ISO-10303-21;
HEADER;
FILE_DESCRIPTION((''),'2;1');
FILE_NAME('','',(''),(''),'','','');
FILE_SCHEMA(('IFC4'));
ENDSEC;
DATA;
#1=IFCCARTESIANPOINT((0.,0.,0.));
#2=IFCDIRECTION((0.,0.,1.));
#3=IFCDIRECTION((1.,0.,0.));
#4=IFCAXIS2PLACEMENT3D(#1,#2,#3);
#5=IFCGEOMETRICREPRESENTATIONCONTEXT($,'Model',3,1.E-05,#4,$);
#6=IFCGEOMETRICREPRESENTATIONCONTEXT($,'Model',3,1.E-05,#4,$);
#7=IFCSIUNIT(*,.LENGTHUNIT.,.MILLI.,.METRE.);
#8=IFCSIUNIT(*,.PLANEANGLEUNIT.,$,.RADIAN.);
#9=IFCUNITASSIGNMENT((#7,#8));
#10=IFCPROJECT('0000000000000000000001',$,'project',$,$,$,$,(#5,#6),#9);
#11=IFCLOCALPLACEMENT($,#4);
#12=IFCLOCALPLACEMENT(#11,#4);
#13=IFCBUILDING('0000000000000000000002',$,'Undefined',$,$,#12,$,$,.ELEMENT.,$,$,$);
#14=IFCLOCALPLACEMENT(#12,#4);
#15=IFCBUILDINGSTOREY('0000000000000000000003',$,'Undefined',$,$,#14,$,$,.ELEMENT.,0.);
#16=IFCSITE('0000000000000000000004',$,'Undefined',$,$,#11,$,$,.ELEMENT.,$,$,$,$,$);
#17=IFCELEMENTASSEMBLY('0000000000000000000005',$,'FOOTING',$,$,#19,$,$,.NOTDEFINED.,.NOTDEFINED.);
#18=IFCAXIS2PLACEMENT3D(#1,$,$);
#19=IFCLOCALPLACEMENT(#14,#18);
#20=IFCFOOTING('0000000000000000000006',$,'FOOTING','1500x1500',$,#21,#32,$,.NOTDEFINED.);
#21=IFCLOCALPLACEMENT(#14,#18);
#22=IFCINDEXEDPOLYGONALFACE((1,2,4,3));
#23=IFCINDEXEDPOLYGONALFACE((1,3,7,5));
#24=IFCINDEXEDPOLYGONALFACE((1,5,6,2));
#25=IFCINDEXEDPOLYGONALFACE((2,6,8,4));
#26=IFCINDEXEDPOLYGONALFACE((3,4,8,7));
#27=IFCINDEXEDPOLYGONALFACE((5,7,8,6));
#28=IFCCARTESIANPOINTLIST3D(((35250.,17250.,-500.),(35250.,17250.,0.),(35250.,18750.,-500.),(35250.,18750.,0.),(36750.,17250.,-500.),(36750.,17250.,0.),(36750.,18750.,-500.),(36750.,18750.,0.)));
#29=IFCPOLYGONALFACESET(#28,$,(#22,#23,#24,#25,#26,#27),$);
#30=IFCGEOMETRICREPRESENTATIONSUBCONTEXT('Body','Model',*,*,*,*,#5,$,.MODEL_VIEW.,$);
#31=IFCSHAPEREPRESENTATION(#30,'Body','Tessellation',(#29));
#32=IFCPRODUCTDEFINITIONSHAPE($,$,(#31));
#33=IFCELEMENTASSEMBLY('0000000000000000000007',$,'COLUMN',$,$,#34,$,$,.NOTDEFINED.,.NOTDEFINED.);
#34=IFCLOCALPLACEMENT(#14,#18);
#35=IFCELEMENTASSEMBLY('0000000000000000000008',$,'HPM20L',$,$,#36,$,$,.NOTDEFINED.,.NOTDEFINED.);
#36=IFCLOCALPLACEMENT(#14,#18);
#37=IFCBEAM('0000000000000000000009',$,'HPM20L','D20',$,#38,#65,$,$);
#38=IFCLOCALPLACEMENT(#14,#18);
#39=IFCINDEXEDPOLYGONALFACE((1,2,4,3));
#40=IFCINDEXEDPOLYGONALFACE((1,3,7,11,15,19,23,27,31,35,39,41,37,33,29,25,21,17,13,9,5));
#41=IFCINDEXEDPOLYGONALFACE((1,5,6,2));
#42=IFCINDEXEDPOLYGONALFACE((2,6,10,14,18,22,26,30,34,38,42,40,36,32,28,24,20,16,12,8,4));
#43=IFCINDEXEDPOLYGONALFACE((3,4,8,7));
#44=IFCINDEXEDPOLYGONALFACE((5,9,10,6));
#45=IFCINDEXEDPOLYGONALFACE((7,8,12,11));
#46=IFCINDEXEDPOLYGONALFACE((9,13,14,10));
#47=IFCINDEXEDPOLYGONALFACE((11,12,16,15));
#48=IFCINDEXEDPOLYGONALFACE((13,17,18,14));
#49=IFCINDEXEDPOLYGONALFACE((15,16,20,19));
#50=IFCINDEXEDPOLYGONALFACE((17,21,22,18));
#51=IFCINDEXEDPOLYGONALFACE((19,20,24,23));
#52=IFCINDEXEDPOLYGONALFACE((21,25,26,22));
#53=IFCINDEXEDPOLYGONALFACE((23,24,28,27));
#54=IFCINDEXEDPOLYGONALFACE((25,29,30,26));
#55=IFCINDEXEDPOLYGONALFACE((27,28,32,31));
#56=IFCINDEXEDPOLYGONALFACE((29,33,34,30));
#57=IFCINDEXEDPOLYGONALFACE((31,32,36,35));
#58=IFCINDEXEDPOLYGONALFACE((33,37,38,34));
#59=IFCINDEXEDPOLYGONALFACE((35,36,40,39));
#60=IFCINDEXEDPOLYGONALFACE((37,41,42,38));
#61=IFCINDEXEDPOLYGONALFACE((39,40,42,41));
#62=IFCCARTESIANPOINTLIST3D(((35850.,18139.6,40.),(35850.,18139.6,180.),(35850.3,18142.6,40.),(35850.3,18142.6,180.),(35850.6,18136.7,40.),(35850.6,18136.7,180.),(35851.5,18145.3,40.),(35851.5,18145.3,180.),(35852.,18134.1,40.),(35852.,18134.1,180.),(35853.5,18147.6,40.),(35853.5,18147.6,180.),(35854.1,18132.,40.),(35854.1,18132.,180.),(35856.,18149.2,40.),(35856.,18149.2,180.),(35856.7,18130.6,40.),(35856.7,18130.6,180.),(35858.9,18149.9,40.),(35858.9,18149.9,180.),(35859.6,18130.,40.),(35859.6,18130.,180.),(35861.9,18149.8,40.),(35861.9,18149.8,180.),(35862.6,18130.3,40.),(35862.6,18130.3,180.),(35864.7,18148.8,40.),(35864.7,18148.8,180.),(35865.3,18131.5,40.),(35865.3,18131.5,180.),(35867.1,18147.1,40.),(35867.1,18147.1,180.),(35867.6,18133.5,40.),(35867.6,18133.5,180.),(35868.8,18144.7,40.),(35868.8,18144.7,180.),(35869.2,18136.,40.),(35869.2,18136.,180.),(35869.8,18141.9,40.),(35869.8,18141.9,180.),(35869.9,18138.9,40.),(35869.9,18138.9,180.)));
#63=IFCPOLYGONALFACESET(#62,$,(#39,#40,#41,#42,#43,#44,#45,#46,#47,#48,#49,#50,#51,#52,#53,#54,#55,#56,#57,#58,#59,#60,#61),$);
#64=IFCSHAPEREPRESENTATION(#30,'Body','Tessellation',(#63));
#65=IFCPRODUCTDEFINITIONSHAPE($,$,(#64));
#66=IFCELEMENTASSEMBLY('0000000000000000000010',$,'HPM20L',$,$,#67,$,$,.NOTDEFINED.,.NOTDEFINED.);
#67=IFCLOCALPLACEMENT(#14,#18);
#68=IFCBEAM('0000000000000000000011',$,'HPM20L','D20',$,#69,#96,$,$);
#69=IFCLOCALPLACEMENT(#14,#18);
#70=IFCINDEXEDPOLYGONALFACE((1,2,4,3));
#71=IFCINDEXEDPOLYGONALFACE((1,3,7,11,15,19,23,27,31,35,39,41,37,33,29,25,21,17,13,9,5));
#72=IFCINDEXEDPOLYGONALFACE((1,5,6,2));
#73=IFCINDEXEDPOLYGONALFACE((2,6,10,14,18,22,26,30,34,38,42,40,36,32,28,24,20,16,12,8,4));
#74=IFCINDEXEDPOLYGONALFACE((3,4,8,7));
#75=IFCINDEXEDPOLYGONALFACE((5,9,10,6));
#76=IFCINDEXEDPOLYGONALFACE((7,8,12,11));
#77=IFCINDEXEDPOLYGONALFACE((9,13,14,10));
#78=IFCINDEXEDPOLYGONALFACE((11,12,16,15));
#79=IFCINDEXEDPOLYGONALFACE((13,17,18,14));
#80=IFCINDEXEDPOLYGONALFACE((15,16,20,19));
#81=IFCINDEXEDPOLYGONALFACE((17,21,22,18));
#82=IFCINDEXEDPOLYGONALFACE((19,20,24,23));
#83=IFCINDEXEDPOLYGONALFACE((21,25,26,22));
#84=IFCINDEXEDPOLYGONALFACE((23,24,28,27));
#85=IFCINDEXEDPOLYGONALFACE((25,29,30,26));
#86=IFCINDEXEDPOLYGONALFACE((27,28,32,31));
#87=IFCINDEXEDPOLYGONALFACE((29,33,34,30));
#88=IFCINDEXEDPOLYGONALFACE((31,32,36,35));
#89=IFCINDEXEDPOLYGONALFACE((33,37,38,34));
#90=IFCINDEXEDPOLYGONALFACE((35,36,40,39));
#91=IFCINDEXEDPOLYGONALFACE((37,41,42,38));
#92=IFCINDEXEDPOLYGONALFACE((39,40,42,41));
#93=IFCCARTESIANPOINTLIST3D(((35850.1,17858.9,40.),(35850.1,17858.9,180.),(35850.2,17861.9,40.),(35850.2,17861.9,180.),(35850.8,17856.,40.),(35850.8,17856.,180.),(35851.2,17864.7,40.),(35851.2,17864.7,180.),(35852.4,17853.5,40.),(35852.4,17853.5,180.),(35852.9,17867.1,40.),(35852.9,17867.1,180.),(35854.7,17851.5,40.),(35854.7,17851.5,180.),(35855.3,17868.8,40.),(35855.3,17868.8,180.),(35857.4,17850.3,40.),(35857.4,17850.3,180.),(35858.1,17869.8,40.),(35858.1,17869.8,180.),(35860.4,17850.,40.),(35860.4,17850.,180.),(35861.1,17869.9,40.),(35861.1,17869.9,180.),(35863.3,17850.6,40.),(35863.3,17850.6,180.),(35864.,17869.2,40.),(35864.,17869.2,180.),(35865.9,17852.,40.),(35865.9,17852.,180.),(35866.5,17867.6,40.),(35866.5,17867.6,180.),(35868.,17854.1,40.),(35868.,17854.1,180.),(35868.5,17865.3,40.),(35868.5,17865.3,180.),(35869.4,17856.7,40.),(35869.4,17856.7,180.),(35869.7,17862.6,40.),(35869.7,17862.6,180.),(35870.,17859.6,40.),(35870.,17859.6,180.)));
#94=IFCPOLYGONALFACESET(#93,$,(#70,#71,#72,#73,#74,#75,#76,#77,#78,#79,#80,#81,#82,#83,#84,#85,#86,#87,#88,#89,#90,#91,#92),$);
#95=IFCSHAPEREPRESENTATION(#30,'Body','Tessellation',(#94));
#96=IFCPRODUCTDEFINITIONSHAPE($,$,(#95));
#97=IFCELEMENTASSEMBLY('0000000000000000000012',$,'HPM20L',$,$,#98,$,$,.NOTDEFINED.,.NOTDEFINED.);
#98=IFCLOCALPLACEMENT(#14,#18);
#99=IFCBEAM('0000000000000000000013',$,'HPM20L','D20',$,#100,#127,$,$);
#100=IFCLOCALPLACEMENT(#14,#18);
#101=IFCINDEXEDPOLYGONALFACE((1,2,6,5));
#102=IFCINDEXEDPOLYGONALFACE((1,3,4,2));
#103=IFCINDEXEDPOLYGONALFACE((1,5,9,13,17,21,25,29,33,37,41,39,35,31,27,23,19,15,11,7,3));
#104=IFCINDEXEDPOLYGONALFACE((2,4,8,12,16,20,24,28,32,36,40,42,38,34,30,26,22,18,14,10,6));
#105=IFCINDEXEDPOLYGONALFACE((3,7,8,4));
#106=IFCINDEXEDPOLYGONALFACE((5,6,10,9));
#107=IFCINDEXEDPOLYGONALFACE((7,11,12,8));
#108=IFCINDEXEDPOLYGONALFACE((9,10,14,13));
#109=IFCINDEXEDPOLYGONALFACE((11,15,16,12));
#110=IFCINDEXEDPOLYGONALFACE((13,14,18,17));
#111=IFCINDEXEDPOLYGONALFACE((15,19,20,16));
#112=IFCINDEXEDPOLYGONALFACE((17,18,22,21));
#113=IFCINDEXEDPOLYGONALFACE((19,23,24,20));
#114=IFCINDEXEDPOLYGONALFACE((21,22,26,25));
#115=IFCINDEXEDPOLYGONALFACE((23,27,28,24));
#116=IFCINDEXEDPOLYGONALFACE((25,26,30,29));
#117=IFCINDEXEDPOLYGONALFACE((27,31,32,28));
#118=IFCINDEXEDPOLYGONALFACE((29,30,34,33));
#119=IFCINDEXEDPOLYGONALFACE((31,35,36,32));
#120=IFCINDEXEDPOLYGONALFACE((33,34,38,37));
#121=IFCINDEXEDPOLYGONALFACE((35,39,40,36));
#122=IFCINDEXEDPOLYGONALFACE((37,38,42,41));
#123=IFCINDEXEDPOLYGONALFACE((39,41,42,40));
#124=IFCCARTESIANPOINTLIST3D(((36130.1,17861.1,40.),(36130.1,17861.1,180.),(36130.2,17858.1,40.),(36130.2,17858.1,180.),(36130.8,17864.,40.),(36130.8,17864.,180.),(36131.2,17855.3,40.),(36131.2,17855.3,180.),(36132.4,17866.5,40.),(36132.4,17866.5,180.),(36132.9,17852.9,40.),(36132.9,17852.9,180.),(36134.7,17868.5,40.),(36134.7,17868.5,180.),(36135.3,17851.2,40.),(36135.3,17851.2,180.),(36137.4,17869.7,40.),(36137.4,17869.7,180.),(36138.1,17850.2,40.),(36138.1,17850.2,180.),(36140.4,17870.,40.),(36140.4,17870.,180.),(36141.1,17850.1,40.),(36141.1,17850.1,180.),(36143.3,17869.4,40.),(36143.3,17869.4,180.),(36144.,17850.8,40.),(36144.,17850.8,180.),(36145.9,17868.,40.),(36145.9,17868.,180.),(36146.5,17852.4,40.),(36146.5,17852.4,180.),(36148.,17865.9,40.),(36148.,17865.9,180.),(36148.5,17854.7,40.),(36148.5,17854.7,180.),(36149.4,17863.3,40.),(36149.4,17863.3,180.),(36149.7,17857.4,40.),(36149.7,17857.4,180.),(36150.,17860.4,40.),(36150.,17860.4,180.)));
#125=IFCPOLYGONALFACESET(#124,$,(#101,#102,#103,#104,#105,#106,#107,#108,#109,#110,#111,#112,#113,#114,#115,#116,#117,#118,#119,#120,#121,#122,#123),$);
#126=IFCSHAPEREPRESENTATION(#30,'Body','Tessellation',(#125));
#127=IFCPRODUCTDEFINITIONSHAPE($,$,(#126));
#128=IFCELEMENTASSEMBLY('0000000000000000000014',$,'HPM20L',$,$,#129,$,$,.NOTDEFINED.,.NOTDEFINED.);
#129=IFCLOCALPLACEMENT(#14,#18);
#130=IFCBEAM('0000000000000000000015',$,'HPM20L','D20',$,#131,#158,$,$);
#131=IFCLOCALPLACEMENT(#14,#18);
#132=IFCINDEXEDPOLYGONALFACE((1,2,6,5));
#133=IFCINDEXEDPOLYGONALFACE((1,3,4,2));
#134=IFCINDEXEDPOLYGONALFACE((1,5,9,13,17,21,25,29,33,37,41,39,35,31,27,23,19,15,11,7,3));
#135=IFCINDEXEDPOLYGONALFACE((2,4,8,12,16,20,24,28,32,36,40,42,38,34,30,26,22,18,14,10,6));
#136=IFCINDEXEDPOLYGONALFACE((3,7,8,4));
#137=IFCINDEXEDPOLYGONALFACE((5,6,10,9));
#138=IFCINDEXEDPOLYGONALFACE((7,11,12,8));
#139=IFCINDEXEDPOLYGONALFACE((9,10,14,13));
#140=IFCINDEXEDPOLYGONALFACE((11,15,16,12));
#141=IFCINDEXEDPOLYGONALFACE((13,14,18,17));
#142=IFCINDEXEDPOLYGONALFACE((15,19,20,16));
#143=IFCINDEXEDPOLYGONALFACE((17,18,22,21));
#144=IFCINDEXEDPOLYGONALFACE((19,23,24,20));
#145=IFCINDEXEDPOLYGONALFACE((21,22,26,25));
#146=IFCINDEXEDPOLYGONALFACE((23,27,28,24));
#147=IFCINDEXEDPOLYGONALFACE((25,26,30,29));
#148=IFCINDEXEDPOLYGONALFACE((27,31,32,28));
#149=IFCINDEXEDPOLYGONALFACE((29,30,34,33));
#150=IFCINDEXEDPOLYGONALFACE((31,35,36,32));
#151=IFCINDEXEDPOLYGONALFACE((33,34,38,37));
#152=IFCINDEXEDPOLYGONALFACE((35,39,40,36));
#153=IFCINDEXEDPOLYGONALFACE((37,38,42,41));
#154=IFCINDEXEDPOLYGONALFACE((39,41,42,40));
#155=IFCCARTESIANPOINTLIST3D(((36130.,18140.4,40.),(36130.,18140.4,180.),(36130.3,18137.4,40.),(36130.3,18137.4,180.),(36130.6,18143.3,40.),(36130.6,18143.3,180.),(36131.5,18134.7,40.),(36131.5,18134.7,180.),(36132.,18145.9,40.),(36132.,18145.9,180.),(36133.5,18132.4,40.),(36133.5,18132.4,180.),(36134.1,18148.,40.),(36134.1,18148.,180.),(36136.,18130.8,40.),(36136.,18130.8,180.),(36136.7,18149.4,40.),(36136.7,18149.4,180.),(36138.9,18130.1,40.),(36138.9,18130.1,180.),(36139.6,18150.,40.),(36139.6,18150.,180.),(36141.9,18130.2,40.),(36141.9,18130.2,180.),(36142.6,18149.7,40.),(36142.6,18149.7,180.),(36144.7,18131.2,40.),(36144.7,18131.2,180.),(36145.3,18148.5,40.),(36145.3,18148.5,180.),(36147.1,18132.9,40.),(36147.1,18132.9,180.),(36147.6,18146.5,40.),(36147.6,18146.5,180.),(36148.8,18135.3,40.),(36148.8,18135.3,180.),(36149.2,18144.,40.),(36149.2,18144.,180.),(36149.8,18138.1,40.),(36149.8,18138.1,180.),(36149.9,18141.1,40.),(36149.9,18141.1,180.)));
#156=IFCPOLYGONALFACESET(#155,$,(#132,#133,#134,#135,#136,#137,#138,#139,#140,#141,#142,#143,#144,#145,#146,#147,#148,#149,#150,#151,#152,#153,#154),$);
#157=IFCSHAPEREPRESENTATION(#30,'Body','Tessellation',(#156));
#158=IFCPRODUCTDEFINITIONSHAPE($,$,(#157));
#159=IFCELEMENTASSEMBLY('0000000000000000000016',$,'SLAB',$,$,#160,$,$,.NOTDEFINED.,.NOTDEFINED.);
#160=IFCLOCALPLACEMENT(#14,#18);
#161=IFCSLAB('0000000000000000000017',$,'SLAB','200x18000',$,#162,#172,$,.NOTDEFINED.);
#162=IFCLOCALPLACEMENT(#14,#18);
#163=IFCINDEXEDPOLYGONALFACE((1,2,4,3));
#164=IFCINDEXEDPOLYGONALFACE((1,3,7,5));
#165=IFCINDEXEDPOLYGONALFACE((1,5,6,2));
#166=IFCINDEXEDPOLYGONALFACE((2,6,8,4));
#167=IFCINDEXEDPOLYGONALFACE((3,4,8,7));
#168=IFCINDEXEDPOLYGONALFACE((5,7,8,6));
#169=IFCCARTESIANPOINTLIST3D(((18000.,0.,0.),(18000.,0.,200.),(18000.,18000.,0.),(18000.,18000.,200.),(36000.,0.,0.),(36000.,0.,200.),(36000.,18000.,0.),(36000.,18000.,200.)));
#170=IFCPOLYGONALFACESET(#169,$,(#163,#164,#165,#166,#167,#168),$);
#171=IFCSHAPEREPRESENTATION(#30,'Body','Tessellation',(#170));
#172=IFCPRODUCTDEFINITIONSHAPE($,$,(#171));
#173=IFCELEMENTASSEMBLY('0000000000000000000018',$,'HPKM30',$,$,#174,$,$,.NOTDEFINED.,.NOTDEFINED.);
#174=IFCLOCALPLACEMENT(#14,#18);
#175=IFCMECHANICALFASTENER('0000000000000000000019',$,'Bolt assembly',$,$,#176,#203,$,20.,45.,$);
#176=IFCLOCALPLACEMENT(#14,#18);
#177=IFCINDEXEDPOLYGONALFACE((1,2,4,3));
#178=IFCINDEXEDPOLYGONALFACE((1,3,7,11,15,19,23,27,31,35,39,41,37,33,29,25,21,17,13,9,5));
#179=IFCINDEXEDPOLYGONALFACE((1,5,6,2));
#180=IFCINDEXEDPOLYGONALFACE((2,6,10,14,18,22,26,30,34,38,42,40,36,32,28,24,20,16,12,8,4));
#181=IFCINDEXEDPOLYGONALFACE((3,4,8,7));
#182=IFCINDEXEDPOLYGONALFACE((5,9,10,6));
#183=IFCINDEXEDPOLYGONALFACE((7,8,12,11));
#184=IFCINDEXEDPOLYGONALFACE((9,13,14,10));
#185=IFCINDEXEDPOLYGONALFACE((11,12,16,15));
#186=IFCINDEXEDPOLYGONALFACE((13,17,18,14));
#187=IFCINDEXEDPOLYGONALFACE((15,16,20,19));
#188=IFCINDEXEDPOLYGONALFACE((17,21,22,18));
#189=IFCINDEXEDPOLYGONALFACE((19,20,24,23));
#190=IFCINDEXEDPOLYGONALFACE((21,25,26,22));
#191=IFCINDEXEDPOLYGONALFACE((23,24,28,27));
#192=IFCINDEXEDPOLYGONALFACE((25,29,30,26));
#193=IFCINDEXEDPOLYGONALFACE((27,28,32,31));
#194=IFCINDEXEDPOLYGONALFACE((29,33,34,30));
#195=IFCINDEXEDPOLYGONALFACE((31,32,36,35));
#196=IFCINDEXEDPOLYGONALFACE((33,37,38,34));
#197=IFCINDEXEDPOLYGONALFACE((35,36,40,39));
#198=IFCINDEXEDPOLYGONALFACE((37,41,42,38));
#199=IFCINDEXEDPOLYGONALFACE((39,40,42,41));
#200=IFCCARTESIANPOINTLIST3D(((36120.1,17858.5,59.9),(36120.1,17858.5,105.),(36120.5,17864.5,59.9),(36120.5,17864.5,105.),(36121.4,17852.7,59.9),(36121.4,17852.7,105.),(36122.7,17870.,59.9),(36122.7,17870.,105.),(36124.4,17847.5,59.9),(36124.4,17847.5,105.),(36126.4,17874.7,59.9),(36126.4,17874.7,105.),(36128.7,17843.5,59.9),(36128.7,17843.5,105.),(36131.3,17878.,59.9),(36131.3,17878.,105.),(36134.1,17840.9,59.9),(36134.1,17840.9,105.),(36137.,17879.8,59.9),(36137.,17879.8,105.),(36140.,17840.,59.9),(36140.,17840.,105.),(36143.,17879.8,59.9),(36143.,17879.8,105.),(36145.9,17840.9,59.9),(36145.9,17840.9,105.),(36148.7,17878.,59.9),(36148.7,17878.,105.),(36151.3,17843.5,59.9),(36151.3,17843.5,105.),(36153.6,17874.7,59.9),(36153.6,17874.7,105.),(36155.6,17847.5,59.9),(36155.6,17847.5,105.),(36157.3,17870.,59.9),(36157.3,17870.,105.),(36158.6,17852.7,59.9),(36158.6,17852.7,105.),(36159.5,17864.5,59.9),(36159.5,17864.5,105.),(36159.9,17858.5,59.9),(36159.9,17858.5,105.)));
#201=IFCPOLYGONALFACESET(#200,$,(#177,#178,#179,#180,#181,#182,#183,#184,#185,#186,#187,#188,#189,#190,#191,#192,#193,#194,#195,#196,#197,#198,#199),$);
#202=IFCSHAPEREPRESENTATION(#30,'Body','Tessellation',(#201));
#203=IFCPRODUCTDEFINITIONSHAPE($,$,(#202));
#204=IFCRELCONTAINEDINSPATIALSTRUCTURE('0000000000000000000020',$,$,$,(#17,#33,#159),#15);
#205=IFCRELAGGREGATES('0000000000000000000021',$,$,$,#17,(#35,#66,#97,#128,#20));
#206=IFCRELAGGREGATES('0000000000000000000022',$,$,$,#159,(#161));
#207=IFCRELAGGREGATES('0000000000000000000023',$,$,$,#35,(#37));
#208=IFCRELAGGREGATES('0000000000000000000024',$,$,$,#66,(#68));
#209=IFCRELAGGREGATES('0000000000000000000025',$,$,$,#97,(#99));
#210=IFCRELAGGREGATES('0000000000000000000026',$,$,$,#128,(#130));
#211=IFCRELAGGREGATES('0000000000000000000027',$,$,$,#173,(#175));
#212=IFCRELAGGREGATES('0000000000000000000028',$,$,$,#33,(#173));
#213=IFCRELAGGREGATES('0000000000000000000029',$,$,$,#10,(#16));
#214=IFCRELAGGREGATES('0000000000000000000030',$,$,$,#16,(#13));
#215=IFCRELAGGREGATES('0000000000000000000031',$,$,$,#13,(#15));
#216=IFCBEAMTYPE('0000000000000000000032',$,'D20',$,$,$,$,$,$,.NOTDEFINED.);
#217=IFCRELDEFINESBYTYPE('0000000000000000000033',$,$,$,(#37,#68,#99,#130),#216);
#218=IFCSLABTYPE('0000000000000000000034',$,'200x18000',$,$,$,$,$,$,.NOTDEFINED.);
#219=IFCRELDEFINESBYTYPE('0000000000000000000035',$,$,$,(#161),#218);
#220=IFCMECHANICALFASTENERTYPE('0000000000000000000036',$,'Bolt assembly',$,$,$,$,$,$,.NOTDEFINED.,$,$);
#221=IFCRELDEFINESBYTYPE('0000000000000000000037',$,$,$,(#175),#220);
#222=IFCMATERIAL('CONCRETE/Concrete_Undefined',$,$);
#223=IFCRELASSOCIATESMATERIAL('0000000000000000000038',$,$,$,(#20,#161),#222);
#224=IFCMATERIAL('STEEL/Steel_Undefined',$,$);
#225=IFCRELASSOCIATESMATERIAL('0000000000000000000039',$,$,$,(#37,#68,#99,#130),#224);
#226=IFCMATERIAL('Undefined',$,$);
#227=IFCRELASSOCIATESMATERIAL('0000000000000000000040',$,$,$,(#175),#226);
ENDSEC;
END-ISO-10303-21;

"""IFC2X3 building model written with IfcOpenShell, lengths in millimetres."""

from ifc_helpers import new_model, si_unit, frame, origin_with_axes, origin_2d_with_axis, place, context, subcontext, project, spatial, polyline, rectangle, circle, outline, extrude, source, transform, mapped, material, type_object, element, aggregate, save


model = new_model("IFC2X3")

# Units and contexts
model_context_1 = context("Model", 3, precision=1e-05, world=origin_with_axes())
model_context_2 = context("Model", 3, precision=1e-05, world=origin_with_axes())
body_context = subcontext(model_context_1, "Body", "Model", "MODEL_VIEW")
ifc_project = project(units=[si_unit("LENGTHUNIT", "METRE", prefix="MILLI"), si_unit("PLANEANGLEUNIT", "RADIAN")], contexts=[model_context_1, model_context_2])

# Site, building, storey
site_placement = place(None, origin_with_axes())
site = spatial("IfcSite", under=ifc_project, at=site_placement, Name="Undefined", CompositionType="ELEMENT")
building_placement = place(site_placement, origin_with_axes())
building = spatial("IfcBuilding", under=site, at=building_placement, Name="Undefined", CompositionType="ELEMENT")
storey_placement = place(building_placement, origin_with_axes())
storey = spatial("IfcBuildingStorey", under=building, at=storey_placement, Name="Undefined", CompositionType="ELEMENT", Elevation=0.0)

# Element assembly, footing
assembly_1_placement = place(storey_placement, origin_with_axes())
assembly_1 = element("IfcElementAssembly", 1, at=assembly_1_placement, inside=storey, Name="FOOTING", AssemblyPlace="NOTDEFINED", PredefinedType="NOTDEFINED")
ifc_material_1 = material(Name="CONCRETE/Concrete_Undefined")
footing_placement = place(assembly_1_placement, frame((36000.0, 18000.0, -500.0), z_axis=(0.0, 1.0, 0.0), x_axis=(0.0, 0.0, 1.0)))
footing = element("IfcFooting", 2, at=footing_placement, material=ifc_material_1, Name="FOOTING", Description="1500x1500", PredefinedType="NOTDEFINED", context=body_context, shape_type="SweptSolid", body=[
    extrude(rectangle(XDim=1500.0, YDim=1500.0, at=origin_2d_with_axis()), frame((500.0, 0.0, 0.0), z_axis=(-1.0, 0.0, 0.0), x_axis=(0.0, -1.0, 0.0)), (0.0, 0.0, 1.0), 500.0),
])

# Element assembly
assembly_2_placement = place(storey_placement, origin_with_axes())
assembly_2 = element("IfcElementAssembly", 3, at=assembly_2_placement, inside=storey, Name="COLUMN", AssemblyPlace="NOTDEFINED", PredefinedType="NOTDEFINED")

# Element assemblies, beams
assembly_3_placement = place(assembly_1_placement, origin_with_axes())
assembly_3 = element("IfcElementAssembly", 4, at=assembly_3_placement, Name="HPM20L", AssemblyPlace="NOTDEFINED", PredefinedType="NOTDEFINED")
ifc_material_2 = material(Name="STEEL/Steel_Undefined")
beam_type = type_object("IfcBeamType", Name="D20", PredefinedType="NOTDEFINED")
beam_1_placement = place(assembly_3_placement, frame((35860.0, 18140.0, 180.0), z_axis=(-0.707107, 0.707107, 0.0), x_axis=(0.0, 0.0, -1.0)))
beam_1 = element("IfcBeam", 5, at=beam_1_placement, type_object=beam_type, material=ifc_material_2, Name="HPM20L", Description="D20", context=body_context, shape_type="SweptSolid", body=[
    extrude(circle(Radius=10.0, at=origin_2d_with_axis()), frame((140.0, 0.0, 0.0), z_axis=(-1.0, 0.0, 0.0), x_axis=(0.0, -1.0, 0.0)), (0.0, 0.0, 1.0), 140.0),
])
assembly_4_placement = place(assembly_1_placement, origin_with_axes())
assembly_4 = element("IfcElementAssembly", 6, at=assembly_4_placement, Name="HPM20L", AssemblyPlace="NOTDEFINED", PredefinedType="NOTDEFINED")
beam_2_placement = place(assembly_4_placement, frame((35860.0, 17860.0, 180.0), z_axis=(-0.707107, -0.707107, 0.0), x_axis=(0.0, 0.0, -1.0)))
beam_2 = element("IfcBeam", 7, at=beam_2_placement, type_object=beam_type, material=ifc_material_2, Name="HPM20L", Description="D20", context=body_context, shape_type="SweptSolid", body=[
    extrude(circle(Radius=10.0, at=origin_2d_with_axis()), frame((140.0, 0.0, 0.0), z_axis=(-1.0, 0.0, 0.0), x_axis=(0.0, -1.0, 0.0)), (0.0, 0.0, 1.0), 140.0),
])
assembly_5_placement = place(assembly_1_placement, origin_with_axes())
assembly_5 = element("IfcElementAssembly", 8, at=assembly_5_placement, Name="HPM20L", AssemblyPlace="NOTDEFINED", PredefinedType="NOTDEFINED")
beam_3_placement = place(assembly_5_placement, frame((36140.0, 17860.0, 180.0), z_axis=(0.707107, -0.707107, 0.0), x_axis=(0.0, 0.0, -1.0)))
beam_3 = element("IfcBeam", 9, at=beam_3_placement, type_object=beam_type, material=ifc_material_2, Name="HPM20L", Description="D20", context=body_context, shape_type="SweptSolid", body=[
    extrude(circle(Radius=10.0, at=origin_2d_with_axis()), frame((140.0, 0.0, 0.0), z_axis=(-1.0, 0.0, 0.0), x_axis=(0.0, -1.0, 0.0)), (0.0, 0.0, 1.0), 140.0),
])

# Element assembly
assembly_6_placement = place(assembly_1_placement, origin_with_axes())
assembly_6 = element("IfcElementAssembly", 10, at=assembly_6_placement, Name="HPM20L", AssemblyPlace="NOTDEFINED", PredefinedType="NOTDEFINED")
aggregate(assembly_1, [assembly_3, assembly_4, assembly_5, assembly_6, footing])

# Beam
beam_4_placement = place(assembly_6_placement, frame((36140.0, 18140.0, 180.0), z_axis=(0.707107, 0.707107, 0.0), x_axis=(0.0, 0.0, -1.0)))
beam_4 = element("IfcBeam", 11, at=beam_4_placement, type_object=beam_type, material=ifc_material_2, Name="HPM20L", Description="D20", context=body_context, shape_type="SweptSolid", body=[
    extrude(circle(Radius=10.0, at=origin_2d_with_axis()), frame((140.0, 0.0, 0.0), z_axis=(-1.0, 0.0, 0.0), x_axis=(0.0, -1.0, 0.0)), (0.0, 0.0, 1.0), 140.0),
])

# Element assembly, slab
assembly_7_placement = place(storey_placement, origin_with_axes())
assembly_7 = element("IfcElementAssembly", 12, at=assembly_7_placement, inside=storey, Name="SLAB", AssemblyPlace="NOTDEFINED", PredefinedType="NOTDEFINED")
slab_type = type_object("IfcSlabType", Name="200x18000", PredefinedType="NOTDEFINED")
slab_placement = place(assembly_7_placement, frame((36000.0, 18000.0, 100.0), z_axis=(0.0, 0.0, 1.0), x_axis=(-1.0, 0.0, 0.0)))
slab = element("IfcSlab", 13, at=slab_placement, type_object=slab_type, material=ifc_material_1, Name="SLAB", Description="200x18000", PredefinedType="NOTDEFINED", context=body_context, shape_type="SweptSolid", body=[
    extrude(outline(polyline([(0.0, 0.0), (18000.0, 0.0), (18000.0, 18000.0), (0.0, 18000.0), (0.0, 0.0)])), frame((0.0, 0.0, -100.0), z_axis=(0.0, 0.0, 1.0), x_axis=(1.0, 0.0, 0.0)), (0.0, 0.0, 1.0), 200.0),
])
aggregate(assembly_7, [slab])

# Element assembly
assembly_8_placement = place(assembly_2_placement, origin_with_axes())
assembly_8 = element("IfcElementAssembly", 14, at=assembly_8_placement, Name="HPKM30", AssemblyPlace="NOTDEFINED", PredefinedType="NOTDEFINED")

# Mechanical fastener
ifc_material_3 = material(Name="Undefined")
mechanical_fastener_type = type_object("IfcMechanicalFastenerType", Name="Bolt assembly")
shared_shape_1 = source(origin_with_axes(), body_context, "Body", "SweptSolid", [
    extrude(circle(Radius=20.0, at=origin_2d_with_axis()), frame((0.0, -45.0, 0.0), z_axis=(0.0, 1.0, 0.0), x_axis=(1.0, 0.0, 0.0)), (0.0, 0.0, 1.0), 45.1),
])
mechanical_fastener_1_placement = place(assembly_8_placement, frame((36140.0, 17860.0, 60.0), z_axis=(1.0, 0.0, 0.0), x_axis=(0.0, -1.0, 0.0)))
mechanical_fastener_1 = element("IfcMechanicalFastener", 15, at=mechanical_fastener_1_placement, type_object=mechanical_fastener_type, material=ifc_material_3, Name="Bolt assembly", NominalDiameter=20.0, NominalLength=45.0, context=body_context, shape_type="MappedRepresentation", body=[
    mapped(shared_shape_1, transform((0.0, 0.0, 0.0))),
])

aggregate(assembly_3, [beam_1])
aggregate(assembly_4, [beam_2])
aggregate(assembly_5, [beam_3])
aggregate(assembly_6, [beam_4])
aggregate(assembly_8, [mechanical_fastener_1])
aggregate(assembly_2, [assembly_8])

save(model, "model.ifc")
